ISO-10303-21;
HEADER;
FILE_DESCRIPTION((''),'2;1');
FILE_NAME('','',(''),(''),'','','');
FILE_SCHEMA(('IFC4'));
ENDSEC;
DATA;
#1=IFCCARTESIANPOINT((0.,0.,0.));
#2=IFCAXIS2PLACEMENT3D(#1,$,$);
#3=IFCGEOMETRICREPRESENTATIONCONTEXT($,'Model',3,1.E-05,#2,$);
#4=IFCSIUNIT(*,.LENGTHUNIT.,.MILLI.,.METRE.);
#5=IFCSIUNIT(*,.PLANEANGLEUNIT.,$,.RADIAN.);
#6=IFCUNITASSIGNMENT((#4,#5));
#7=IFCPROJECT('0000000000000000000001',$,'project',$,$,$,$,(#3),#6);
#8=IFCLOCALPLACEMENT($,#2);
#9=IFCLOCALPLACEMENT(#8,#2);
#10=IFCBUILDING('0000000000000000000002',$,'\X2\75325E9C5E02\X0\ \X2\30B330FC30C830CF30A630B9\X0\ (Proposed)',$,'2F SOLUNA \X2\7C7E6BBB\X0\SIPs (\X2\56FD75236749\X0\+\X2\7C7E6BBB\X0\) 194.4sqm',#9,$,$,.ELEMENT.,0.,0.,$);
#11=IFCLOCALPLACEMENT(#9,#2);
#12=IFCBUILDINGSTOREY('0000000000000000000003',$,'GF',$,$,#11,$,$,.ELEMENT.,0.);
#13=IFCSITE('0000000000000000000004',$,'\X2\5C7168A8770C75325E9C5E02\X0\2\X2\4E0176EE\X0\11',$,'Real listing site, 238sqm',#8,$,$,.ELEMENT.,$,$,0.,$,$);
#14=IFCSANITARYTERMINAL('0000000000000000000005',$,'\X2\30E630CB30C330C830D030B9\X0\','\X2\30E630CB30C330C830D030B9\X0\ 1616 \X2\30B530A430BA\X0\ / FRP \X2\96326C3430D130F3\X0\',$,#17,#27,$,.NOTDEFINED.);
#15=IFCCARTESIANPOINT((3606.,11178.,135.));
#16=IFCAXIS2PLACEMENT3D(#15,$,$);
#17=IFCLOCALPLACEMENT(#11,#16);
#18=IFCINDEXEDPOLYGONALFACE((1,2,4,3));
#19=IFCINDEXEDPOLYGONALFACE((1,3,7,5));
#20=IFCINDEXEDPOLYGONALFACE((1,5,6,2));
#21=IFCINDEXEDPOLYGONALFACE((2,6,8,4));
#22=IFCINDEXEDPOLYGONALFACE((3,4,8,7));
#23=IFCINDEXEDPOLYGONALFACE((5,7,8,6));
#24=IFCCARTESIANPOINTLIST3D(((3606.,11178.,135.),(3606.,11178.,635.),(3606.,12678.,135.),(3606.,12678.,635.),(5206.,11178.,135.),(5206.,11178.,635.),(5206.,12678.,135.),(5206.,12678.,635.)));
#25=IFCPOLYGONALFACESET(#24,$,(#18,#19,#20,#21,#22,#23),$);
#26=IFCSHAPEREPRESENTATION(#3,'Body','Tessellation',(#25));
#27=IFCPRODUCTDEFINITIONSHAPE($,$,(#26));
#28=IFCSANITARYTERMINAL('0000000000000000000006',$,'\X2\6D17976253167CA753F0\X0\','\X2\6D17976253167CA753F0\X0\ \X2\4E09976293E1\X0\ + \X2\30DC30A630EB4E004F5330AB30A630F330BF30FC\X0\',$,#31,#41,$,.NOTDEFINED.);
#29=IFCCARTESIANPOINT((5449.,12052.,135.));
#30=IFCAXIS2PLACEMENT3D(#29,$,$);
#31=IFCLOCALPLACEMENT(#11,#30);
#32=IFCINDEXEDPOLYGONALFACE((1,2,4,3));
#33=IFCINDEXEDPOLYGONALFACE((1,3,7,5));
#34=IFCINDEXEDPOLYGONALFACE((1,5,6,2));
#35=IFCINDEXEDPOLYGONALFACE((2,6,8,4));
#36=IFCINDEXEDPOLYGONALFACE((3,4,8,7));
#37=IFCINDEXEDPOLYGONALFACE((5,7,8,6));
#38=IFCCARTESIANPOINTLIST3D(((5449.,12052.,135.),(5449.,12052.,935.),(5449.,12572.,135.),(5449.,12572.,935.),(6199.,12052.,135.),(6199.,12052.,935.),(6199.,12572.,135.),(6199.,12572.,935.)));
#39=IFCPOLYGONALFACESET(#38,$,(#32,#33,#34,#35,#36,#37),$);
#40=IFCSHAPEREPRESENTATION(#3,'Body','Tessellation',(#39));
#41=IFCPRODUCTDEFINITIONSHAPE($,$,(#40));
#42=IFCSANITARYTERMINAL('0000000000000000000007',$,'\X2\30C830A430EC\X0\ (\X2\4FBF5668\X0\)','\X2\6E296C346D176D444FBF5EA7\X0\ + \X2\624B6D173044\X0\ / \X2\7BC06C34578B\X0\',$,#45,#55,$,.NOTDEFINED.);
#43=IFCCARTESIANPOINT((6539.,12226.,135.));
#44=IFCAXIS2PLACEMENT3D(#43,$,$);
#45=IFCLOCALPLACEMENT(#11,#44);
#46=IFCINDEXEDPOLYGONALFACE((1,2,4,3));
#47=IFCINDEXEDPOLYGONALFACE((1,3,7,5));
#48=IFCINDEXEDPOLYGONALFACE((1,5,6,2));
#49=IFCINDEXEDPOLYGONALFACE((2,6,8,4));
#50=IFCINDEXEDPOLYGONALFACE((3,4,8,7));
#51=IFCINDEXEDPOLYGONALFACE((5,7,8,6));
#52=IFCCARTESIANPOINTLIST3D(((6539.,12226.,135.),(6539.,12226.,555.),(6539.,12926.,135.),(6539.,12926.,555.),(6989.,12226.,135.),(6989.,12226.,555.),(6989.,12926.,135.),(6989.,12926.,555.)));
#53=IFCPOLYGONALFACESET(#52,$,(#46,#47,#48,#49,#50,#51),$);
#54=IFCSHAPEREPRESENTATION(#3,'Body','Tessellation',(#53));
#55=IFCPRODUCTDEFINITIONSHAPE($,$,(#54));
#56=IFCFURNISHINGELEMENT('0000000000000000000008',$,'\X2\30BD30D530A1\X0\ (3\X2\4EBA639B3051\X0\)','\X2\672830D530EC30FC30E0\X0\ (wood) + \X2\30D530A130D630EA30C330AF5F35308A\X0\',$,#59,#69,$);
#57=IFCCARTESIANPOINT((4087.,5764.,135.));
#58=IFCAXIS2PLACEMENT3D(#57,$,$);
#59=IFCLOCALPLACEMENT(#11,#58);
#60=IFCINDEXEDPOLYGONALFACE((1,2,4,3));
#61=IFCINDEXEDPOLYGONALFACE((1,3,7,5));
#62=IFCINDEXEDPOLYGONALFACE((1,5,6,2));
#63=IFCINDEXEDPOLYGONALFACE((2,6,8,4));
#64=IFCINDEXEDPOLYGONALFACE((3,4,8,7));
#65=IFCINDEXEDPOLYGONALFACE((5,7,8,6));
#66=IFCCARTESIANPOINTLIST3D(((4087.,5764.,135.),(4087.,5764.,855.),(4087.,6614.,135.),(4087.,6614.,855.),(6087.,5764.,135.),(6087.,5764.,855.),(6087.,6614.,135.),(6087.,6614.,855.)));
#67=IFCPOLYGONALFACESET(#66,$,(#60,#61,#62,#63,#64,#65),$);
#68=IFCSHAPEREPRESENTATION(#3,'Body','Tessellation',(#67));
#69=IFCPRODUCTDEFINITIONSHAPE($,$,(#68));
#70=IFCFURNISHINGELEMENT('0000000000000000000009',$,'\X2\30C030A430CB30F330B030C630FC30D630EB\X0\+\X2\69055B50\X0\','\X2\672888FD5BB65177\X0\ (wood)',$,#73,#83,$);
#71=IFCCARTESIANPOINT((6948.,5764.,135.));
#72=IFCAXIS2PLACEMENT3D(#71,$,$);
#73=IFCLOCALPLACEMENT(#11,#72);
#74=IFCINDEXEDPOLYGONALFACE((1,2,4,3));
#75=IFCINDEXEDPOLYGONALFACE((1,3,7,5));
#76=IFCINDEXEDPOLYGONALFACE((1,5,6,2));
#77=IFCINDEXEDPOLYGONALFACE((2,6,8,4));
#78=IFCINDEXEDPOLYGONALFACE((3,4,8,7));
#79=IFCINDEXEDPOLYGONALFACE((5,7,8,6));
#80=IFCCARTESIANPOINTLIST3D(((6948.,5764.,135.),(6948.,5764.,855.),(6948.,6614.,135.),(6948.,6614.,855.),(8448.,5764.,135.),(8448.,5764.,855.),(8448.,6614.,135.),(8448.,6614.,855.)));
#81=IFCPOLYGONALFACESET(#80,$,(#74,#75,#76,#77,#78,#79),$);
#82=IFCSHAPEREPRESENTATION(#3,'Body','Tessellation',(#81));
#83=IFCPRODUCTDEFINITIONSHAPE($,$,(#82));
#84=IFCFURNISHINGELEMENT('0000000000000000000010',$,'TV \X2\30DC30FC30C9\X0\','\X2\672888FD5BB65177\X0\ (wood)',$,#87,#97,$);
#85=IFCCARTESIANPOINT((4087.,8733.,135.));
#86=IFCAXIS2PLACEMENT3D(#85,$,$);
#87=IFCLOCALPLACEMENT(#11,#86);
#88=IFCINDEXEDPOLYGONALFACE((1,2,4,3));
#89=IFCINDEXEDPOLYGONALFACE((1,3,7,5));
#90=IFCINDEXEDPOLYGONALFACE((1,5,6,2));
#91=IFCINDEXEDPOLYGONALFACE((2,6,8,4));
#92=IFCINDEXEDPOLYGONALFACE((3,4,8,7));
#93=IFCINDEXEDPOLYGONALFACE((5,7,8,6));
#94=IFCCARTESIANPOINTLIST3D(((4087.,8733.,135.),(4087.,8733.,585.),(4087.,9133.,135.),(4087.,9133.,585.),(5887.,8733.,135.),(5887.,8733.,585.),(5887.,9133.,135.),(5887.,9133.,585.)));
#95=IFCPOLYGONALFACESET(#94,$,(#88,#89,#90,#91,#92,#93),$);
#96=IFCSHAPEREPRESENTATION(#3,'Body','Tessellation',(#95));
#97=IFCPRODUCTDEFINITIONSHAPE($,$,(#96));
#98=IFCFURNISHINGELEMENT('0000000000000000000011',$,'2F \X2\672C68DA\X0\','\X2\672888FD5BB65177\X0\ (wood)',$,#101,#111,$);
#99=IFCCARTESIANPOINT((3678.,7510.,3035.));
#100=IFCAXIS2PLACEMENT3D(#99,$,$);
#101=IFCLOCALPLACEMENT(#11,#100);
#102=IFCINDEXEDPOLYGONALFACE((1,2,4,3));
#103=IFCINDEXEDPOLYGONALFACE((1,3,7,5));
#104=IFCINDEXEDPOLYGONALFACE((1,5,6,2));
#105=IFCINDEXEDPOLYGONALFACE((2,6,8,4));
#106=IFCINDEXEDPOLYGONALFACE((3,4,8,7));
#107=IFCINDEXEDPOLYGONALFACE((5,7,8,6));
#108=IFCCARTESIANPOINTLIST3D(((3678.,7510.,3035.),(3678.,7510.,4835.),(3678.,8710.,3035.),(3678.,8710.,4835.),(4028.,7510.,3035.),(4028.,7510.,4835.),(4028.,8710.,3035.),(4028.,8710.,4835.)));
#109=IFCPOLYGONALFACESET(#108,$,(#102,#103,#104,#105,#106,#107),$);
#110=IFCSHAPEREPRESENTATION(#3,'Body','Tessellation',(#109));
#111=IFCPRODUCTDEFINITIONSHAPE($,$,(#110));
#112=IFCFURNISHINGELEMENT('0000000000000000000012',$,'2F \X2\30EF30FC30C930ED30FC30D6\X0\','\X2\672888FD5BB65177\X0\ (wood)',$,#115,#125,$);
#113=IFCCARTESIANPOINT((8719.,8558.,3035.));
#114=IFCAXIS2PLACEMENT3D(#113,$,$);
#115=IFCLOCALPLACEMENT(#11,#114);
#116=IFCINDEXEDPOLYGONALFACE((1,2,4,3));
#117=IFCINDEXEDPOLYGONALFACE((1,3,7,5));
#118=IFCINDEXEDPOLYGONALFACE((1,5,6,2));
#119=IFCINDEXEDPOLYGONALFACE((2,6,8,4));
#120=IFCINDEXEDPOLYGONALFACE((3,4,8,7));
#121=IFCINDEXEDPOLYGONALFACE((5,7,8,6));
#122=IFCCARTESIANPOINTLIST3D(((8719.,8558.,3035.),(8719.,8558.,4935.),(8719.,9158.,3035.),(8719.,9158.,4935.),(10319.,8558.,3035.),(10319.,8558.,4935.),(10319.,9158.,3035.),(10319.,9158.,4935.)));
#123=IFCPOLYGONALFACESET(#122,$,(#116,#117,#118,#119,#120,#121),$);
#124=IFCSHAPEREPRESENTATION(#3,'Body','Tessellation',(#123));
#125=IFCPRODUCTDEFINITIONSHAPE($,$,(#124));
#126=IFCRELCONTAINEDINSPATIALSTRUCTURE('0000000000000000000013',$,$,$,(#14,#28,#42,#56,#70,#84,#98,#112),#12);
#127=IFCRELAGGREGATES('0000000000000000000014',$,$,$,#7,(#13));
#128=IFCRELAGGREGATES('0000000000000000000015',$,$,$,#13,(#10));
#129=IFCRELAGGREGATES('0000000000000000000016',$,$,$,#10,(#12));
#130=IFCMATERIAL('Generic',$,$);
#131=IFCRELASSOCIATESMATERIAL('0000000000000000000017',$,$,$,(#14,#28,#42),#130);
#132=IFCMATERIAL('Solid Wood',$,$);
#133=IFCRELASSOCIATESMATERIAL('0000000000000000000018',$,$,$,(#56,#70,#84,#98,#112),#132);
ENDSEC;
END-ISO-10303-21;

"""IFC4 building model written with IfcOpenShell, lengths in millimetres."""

from ifc_helpers import new_model, si_unit, frame, frame_2d, origin, place, context, project, spatial, rectangle, extrude, material, element, save


model = new_model("IFC4")

# Units and contexts
model_context = context("Model", 3, precision=1e-05, world=origin())
ifc_project = project(units=[si_unit("LENGTHUNIT", "METRE", prefix="MILLI"), si_unit("PLANEANGLEUNIT", "RADIAN")], contexts=[model_context])

# Site, building, storey
site_placement = place(None, origin())
site = spatial("IfcSite", under=ifc_project, at=site_placement, Name="山梨県甲府市2丁目11", ObjectType="Real listing site, 238sqm", CompositionType="ELEMENT", RefElevation=0.0)
building_placement = place(site_placement, origin())
building = spatial("IfcBuilding", under=site, at=building_placement, Name="甲府市 コートハウス (Proposed)", ObjectType="2F SOLUNA 籾殻SIPs (国産杉+籾殻) 194.4sqm", CompositionType="ELEMENT", ElevationOfRefHeight=0.0, ElevationOfTerrain=0.0)
storey_placement = place(building_placement, origin())
storey = spatial("IfcBuildingStorey", under=building, at=storey_placement, Name="GF", CompositionType="ELEMENT", Elevation=0.0)

# Shared definitions
ifc_material_1 = material(Name="Generic")

# Shared definitions
ifc_material_2 = material(Name="Solid Wood")

# Sanitary terminals
sanitary_terminal_1_placement = place(storey_placement, frame((3606.0, 11178.0, 135.0)))
element("IfcSanitaryTerminal", 1, at=sanitary_terminal_1_placement, inside=storey, material=ifc_material_1, Name="ユニットバス", Description="ユニットバス 1616 サイズ / FRP 防水パン", PredefinedType="NOTDEFINED", context=model_context, shape_type="SweptSolid", body=[
    extrude(rectangle(XDim=1600.0, YDim=1500.0, at=frame_2d((800.0, 750.0))), frame((3606.0, 11178.0, 135.0)), (0.0, 0.0, 1.0), 500.0),
])
sanitary_terminal_2_placement = place(storey_placement, frame((5449.0, 12052.0, 135.0)))
element("IfcSanitaryTerminal", 2, at=sanitary_terminal_2_placement, inside=storey, material=ifc_material_1, Name="洗面化粧台", Description="洗面化粧台 三面鏡 + ボウル一体カウンター", PredefinedType="NOTDEFINED", context=model_context, shape_type="SweptSolid", body=[
    extrude(rectangle(XDim=750.0, YDim=520.0, at=frame_2d((375.0, 260.0))), frame((5449.0, 12052.0, 135.0)), (0.0, 0.0, 1.0), 800.0),
])
sanitary_terminal_3_placement = place(storey_placement, frame((6539.0, 12226.0, 135.0)))
element("IfcSanitaryTerminal", 3, at=sanitary_terminal_3_placement, inside=storey, material=ifc_material_1, Name="トイレ (便器)", Description="温水洗浄便座 + 手洗い / 節水型", PredefinedType="NOTDEFINED", context=model_context, shape_type="SweptSolid", body=[
    extrude(rectangle(XDim=450.0, YDim=700.0, at=frame_2d((225.0, 350.0))), frame((6539.0, 12226.0, 135.0)), (0.0, 0.0, 1.0), 420.0),
])

# Furnishing elements
furnishing_1_placement = place(storey_placement, frame((4087.0, 5764.0, 135.0)))
element("IfcFurnishingElement", 4, at=furnishing_1_placement, inside=storey, material=ifc_material_2, Name="ソファ (3人掛け)", Description="木フレーム (wood) + ファブリック張り", context=model_context, shape_type="SweptSolid", body=[
    extrude(rectangle(XDim=2000.0, YDim=850.0, at=frame_2d((1000.0, 425.0))), frame((4087.0, 5764.0, 135.0)), (0.0, 0.0, 1.0), 720.0),
])
furnishing_2_placement = place(storey_placement, frame((6948.0, 5764.0, 135.0)))
element("IfcFurnishingElement", 5, at=furnishing_2_placement, inside=storey, material=ifc_material_2, Name="ダイニングテーブル+椅子", Description="木製家具 (wood)", context=model_context, shape_type="SweptSolid", body=[
    extrude(rectangle(XDim=1500.0, YDim=850.0, at=frame_2d((750.0, 425.0))), frame((6948.0, 5764.0, 135.0)), (0.0, 0.0, 1.0), 720.0),
])
furnishing_3_placement = place(storey_placement, frame((4087.0, 8733.0, 135.0)))
element("IfcFurnishingElement", 6, at=furnishing_3_placement, inside=storey, material=ifc_material_2, Name="TV ボード", Description="木製家具 (wood)", context=model_context, shape_type="SweptSolid", body=[
    extrude(rectangle(XDim=1800.0, YDim=400.0, at=frame_2d((900.0, 200.0))), frame((4087.0, 8733.0, 135.0)), (0.0, 0.0, 1.0), 450.0),
])
furnishing_4_placement = place(storey_placement, frame((3678.0, 7510.0, 3035.0)))
element("IfcFurnishingElement", 7, at=furnishing_4_placement, inside=storey, material=ifc_material_2, Name="2F 本棚", Description="木製家具 (wood)", context=model_context, shape_type="SweptSolid", body=[
    extrude(rectangle(XDim=350.0, YDim=1200.0, at=frame_2d((175.0, 600.0))), frame((3678.0, 7510.0, 3035.0)), (0.0, 0.0, 1.0), 1800.0),
])
furnishing_5_placement = place(storey_placement, frame((8719.0, 8558.0, 3035.0)))
element("IfcFurnishingElement", 8, at=furnishing_5_placement, inside=storey, material=ifc_material_2, Name="2F ワードローブ", Description="木製家具 (wood)", context=model_context, shape_type="SweptSolid", body=[
    extrude(rectangle(XDim=1600.0, YDim=600.0, at=frame_2d((800.0, 300.0))), frame((8719.0, 8558.0, 3035.0)), (0.0, 0.0, 1.0), 1900.0),
])

save(model, "model.ifc")
